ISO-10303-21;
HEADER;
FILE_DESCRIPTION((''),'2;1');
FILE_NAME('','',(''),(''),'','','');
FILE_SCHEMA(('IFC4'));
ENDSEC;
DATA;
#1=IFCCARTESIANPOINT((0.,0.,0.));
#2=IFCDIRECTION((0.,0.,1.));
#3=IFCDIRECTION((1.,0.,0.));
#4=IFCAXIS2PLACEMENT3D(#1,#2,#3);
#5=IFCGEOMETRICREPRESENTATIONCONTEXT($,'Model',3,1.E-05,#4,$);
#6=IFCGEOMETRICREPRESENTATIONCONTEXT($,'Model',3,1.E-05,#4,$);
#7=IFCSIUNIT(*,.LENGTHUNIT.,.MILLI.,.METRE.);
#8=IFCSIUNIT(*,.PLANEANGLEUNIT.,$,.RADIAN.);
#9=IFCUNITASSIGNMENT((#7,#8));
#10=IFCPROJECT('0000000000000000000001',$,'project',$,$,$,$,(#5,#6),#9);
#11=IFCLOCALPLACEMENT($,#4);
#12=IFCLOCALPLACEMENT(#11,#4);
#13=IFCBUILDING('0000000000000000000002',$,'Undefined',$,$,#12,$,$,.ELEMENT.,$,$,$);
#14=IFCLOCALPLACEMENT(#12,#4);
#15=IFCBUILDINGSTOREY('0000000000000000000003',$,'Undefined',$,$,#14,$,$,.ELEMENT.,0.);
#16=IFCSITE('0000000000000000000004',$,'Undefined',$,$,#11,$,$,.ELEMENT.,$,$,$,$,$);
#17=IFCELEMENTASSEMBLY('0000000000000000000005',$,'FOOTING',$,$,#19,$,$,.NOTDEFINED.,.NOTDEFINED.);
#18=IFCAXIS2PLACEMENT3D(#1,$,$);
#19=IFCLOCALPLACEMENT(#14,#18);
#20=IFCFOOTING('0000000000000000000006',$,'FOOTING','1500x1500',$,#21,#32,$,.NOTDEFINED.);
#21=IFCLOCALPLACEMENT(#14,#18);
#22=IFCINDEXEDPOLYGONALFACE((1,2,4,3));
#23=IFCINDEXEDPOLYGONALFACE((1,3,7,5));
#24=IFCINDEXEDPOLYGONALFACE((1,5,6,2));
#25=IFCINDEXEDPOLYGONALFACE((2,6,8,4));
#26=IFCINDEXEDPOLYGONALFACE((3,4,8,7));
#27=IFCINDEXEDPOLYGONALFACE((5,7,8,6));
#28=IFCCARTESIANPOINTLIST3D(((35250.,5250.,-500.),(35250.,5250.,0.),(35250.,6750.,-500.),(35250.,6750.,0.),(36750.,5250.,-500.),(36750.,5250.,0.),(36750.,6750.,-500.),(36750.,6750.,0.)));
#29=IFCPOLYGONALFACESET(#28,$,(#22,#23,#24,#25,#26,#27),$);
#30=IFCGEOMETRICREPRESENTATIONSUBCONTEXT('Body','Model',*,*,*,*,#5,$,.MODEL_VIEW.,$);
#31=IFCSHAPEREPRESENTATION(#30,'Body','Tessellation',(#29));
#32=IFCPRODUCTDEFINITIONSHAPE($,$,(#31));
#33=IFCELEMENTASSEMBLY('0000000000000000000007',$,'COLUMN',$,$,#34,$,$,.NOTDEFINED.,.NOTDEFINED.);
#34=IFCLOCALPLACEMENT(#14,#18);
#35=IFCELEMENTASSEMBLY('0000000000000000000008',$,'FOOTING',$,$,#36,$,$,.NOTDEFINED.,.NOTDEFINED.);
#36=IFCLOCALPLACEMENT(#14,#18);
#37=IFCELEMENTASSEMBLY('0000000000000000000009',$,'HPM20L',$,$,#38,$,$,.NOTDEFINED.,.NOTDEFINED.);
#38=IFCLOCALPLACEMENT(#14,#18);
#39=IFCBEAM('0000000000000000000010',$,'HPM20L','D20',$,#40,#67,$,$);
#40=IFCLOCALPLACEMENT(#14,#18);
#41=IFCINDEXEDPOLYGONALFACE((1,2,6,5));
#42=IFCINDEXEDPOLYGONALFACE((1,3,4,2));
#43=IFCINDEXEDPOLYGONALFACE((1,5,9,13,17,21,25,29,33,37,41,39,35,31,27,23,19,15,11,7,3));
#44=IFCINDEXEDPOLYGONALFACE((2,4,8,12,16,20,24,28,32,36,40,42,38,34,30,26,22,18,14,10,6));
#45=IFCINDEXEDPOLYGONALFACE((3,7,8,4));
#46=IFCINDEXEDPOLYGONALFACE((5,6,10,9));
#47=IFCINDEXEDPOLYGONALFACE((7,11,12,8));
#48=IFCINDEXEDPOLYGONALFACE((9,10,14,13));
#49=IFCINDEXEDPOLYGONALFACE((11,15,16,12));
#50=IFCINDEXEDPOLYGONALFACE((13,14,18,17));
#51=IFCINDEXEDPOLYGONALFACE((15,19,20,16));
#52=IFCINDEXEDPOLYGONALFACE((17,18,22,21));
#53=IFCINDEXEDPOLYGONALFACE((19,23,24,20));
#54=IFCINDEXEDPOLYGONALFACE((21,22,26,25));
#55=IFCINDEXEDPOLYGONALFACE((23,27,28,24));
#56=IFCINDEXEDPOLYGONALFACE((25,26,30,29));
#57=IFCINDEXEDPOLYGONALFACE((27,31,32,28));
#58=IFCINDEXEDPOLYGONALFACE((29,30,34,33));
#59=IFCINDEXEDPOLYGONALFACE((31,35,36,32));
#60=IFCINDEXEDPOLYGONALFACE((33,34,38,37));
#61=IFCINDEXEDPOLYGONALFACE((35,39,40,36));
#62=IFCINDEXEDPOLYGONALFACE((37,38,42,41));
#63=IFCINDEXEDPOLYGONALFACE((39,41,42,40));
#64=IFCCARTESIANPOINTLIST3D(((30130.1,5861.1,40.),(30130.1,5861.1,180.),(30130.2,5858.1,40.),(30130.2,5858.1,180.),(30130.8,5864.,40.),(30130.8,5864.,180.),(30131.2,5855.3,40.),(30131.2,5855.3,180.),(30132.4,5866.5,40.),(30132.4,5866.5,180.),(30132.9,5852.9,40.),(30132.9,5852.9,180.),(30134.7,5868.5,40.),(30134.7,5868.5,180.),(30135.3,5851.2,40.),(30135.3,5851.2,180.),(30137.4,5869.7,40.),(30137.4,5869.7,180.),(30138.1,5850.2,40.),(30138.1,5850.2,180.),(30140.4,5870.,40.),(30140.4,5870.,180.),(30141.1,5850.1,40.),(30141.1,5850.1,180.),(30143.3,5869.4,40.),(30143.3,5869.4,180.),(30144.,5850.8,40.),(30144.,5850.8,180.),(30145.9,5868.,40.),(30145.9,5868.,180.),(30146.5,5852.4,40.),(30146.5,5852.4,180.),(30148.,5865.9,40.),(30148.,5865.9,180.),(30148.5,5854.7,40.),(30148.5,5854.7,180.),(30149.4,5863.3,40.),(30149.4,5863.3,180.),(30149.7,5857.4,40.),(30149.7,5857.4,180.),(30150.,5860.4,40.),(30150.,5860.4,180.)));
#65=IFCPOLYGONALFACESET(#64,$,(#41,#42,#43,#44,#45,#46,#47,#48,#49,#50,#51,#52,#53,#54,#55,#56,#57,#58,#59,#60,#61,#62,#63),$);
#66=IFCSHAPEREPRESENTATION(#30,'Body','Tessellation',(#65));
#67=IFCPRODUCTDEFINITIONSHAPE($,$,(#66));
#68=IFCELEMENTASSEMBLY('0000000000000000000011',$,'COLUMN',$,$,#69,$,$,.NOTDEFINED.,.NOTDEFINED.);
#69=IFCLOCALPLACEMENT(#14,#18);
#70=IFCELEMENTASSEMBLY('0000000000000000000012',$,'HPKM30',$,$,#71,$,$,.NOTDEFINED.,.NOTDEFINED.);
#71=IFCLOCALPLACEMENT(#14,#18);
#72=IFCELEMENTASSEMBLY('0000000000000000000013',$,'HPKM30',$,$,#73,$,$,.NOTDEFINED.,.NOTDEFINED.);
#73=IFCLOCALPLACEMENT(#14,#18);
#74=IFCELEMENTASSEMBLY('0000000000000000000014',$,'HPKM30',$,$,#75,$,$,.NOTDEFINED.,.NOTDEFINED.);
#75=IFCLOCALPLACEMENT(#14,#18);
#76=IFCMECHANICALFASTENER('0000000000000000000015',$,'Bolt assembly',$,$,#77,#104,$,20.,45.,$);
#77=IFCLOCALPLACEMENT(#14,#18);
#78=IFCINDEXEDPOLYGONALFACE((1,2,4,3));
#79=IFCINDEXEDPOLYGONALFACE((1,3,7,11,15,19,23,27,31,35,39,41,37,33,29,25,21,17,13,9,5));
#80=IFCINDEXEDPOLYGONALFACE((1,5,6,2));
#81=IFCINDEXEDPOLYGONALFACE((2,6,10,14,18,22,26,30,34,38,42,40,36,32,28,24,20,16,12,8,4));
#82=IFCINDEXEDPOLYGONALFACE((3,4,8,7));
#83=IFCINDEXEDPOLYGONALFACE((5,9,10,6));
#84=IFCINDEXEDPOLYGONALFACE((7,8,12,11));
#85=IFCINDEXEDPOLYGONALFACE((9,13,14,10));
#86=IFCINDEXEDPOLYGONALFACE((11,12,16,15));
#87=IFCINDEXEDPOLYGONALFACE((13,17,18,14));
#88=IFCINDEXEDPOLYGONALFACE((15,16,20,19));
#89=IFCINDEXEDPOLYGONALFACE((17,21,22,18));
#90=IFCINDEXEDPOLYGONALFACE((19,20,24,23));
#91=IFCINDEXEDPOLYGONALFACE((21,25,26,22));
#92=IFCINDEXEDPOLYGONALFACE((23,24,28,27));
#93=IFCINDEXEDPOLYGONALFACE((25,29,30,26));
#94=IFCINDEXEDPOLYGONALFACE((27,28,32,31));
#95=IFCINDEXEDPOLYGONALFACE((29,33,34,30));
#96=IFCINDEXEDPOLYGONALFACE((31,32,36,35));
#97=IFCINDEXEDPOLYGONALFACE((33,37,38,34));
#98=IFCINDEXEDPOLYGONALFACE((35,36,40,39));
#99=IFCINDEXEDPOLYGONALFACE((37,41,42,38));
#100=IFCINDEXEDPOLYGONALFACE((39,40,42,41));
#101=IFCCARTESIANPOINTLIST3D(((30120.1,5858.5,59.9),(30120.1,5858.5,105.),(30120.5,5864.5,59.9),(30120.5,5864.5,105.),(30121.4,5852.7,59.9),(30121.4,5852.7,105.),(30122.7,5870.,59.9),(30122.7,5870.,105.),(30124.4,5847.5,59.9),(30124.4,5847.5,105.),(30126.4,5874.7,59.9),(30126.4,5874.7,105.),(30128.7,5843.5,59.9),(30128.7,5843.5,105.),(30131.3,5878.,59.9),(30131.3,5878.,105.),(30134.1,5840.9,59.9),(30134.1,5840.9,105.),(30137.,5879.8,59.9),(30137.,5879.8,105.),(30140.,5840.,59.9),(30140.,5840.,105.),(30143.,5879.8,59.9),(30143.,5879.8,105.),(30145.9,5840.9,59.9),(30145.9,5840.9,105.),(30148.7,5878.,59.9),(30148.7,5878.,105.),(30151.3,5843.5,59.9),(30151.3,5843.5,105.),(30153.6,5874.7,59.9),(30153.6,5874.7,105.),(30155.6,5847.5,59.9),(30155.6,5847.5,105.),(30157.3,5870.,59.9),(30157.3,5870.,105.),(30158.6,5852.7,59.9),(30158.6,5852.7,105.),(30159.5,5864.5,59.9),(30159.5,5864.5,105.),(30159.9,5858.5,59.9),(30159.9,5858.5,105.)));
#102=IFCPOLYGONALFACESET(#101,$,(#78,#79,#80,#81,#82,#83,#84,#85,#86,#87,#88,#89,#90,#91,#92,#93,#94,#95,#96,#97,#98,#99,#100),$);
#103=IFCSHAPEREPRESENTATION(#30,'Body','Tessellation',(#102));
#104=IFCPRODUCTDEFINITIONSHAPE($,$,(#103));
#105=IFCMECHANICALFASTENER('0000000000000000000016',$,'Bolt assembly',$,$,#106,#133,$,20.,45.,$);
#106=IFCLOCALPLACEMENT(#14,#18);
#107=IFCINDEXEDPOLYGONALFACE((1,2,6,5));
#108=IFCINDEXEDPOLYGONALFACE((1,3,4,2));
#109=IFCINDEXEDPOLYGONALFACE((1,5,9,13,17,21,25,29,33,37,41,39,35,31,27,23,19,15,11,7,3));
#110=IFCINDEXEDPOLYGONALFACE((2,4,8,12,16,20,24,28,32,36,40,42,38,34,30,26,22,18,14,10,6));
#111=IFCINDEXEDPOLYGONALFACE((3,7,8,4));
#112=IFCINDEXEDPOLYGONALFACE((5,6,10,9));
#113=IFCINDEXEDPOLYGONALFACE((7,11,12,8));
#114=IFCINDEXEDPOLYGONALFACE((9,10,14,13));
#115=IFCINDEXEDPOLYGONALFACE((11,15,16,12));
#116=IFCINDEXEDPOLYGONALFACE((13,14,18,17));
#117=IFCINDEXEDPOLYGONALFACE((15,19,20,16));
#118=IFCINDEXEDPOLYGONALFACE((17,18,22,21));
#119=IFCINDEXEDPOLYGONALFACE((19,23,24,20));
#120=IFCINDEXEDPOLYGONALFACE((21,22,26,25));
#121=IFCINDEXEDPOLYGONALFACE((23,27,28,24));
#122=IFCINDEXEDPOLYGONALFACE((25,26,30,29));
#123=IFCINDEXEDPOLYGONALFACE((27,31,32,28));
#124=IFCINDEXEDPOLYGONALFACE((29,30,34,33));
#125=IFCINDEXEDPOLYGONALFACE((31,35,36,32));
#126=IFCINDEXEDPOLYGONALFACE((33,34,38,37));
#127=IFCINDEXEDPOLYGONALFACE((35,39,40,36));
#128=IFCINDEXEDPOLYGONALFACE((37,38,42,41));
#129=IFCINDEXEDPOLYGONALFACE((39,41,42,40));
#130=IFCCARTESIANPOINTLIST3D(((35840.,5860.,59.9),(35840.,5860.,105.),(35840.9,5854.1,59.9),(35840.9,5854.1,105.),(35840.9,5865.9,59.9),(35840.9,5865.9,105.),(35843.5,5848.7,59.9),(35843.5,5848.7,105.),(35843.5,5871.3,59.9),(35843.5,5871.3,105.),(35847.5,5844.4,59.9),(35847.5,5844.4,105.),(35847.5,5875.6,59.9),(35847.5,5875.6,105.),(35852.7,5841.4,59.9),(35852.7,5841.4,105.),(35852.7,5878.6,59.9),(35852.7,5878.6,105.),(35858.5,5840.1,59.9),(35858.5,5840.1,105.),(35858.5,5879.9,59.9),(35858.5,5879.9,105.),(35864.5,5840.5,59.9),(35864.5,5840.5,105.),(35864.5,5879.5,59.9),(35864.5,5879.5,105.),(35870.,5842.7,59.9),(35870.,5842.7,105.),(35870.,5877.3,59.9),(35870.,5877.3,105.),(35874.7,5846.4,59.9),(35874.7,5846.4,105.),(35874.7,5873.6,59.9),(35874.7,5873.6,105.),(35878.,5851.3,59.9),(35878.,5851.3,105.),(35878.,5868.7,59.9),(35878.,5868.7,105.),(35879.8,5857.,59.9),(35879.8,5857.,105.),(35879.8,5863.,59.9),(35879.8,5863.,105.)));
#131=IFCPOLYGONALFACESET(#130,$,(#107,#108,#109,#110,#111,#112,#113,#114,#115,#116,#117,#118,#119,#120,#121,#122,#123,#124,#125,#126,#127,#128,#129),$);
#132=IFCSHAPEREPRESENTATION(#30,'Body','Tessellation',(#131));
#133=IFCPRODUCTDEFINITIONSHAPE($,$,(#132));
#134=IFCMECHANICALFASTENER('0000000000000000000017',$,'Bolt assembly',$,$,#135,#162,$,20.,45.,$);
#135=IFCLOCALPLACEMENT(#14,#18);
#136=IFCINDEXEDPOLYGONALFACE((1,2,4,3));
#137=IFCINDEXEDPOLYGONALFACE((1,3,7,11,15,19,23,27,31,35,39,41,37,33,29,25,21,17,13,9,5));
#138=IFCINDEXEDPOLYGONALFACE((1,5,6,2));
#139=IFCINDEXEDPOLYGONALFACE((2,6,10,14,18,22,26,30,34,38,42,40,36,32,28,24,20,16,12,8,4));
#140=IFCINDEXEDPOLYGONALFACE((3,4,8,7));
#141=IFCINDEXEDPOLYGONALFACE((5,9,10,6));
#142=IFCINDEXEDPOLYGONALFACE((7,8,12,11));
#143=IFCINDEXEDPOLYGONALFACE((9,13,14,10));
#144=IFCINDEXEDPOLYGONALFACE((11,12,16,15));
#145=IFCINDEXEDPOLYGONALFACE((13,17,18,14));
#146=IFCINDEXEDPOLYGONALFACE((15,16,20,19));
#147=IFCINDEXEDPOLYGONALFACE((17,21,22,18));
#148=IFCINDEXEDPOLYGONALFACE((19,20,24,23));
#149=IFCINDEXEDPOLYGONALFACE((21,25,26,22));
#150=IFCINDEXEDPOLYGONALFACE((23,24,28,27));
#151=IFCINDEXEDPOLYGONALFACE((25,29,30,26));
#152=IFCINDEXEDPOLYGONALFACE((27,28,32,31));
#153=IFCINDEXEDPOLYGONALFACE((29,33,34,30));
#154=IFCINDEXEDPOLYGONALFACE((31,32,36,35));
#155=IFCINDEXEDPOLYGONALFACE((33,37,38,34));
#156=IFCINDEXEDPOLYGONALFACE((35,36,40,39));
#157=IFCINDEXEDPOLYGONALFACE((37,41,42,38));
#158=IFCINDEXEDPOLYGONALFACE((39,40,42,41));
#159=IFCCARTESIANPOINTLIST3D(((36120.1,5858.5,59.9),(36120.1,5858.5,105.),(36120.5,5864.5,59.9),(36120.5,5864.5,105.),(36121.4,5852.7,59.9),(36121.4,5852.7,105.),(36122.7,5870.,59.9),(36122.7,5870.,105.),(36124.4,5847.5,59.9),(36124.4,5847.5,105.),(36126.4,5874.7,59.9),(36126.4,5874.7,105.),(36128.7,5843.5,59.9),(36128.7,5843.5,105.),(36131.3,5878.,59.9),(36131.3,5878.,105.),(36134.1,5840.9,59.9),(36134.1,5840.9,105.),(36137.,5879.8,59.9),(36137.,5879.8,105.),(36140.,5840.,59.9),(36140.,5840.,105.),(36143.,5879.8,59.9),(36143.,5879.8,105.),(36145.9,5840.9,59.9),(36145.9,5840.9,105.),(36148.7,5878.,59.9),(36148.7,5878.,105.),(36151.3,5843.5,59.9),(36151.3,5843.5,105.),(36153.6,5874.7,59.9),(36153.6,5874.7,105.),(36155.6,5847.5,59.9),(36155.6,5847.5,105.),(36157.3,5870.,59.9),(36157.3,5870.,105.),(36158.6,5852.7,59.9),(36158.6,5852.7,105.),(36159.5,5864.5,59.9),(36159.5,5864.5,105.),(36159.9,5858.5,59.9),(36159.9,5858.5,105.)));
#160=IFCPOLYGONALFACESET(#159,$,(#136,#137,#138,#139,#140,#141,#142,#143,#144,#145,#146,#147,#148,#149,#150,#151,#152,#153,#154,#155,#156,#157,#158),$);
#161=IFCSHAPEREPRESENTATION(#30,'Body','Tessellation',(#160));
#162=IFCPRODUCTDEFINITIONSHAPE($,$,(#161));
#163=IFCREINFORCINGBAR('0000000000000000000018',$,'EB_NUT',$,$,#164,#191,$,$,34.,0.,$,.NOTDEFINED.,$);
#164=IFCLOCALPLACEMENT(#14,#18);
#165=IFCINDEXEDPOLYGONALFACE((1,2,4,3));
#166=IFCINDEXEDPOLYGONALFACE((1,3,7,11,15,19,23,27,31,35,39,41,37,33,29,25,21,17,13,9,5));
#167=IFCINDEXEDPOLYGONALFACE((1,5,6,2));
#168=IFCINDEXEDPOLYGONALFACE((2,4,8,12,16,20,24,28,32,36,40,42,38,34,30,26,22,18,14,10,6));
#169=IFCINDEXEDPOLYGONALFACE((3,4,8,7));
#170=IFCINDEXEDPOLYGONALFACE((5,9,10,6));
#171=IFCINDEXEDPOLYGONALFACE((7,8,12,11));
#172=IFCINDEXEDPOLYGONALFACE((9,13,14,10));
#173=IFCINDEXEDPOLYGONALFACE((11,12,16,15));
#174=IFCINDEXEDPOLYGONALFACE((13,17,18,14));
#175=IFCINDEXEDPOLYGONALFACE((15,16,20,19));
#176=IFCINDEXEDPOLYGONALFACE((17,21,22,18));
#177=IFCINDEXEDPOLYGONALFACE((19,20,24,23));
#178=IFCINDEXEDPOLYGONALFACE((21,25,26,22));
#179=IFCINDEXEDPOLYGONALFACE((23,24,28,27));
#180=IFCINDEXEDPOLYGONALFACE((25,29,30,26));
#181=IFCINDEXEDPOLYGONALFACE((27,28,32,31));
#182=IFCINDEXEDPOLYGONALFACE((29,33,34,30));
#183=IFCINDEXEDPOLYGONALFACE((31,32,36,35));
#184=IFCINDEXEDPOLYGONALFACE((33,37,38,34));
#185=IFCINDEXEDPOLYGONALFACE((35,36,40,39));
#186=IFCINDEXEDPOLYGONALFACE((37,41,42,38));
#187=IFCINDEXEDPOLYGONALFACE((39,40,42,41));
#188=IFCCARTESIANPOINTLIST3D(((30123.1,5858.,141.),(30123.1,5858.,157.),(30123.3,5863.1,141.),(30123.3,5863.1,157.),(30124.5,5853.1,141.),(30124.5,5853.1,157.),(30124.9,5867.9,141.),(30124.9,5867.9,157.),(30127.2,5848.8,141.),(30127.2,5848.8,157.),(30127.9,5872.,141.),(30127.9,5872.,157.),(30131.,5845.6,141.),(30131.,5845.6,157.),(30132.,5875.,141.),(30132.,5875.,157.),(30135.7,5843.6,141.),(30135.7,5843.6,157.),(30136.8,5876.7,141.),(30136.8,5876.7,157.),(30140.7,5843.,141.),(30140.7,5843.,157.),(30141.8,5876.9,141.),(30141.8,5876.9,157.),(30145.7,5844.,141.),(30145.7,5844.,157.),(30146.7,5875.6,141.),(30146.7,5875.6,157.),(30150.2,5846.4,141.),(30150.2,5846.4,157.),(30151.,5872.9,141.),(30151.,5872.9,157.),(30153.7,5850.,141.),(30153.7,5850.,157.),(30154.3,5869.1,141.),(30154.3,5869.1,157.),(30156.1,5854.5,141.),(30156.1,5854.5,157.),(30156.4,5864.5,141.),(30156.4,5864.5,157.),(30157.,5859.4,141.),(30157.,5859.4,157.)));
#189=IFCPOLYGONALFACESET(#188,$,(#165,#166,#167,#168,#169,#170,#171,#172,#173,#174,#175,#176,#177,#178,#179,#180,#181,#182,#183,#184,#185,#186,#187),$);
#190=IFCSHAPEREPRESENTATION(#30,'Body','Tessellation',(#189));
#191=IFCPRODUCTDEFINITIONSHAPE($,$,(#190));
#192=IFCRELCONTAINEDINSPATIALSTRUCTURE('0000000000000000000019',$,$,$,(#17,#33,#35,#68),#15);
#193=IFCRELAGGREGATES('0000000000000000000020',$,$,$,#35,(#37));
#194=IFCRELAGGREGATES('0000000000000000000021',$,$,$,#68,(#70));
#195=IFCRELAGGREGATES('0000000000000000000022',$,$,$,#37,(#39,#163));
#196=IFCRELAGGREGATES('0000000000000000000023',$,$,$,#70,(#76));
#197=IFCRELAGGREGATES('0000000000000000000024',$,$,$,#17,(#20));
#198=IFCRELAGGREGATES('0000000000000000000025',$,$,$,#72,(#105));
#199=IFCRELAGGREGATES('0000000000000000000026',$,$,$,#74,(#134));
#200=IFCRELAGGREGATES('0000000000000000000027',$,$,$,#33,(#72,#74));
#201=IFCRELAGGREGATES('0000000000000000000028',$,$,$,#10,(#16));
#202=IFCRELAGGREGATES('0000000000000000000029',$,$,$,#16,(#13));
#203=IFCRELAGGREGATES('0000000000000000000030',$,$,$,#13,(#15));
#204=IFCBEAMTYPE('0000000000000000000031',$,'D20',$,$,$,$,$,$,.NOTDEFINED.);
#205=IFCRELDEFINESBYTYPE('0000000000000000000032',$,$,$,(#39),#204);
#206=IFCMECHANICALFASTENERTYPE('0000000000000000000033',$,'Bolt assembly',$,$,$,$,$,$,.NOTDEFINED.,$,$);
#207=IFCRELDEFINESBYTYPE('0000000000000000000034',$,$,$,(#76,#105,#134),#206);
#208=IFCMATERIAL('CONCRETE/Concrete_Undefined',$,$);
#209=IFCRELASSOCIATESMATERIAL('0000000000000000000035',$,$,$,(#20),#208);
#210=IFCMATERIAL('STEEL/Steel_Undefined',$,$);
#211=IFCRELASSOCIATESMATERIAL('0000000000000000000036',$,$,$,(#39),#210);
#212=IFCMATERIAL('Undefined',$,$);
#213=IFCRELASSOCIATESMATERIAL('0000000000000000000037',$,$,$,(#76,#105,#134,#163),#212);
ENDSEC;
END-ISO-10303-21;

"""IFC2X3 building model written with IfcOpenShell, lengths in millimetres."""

from ifc_helpers import new_model, entity, si_unit, frame, origin_with_axes, origin_2d_with_axis, place, context, subcontext, project, spatial, rectangle, circle, extrude, source, transform, mapped, material, type_object, element, aggregate, save


model = new_model("IFC2X3")

# Units and contexts
model_context_1 = context("Model", 3, precision=1e-05, world=origin_with_axes())
model_context_2 = context("Model", 3, precision=1e-05, world=origin_with_axes())
body_context = subcontext(model_context_1, "Body", "Model", "MODEL_VIEW")
ifc_project = project(units=[si_unit("LENGTHUNIT", "METRE", prefix="MILLI"), si_unit("PLANEANGLEUNIT", "RADIAN")], contexts=[model_context_1, model_context_2])

# Site, building, storey
site_placement = place(None, origin_with_axes())
site = spatial("IfcSite", under=ifc_project, at=site_placement, Name="Undefined", CompositionType="ELEMENT")
building_placement = place(site_placement, origin_with_axes())
building = spatial("IfcBuilding", under=site, at=building_placement, Name="Undefined", CompositionType="ELEMENT")
storey_placement = place(building_placement, origin_with_axes())
storey = spatial("IfcBuildingStorey", under=building, at=storey_placement, Name="Undefined", CompositionType="ELEMENT", Elevation=0.0)

# Element assembly, footing
assembly_1_placement = place(storey_placement, origin_with_axes())
assembly_1 = element("IfcElementAssembly", 1, at=assembly_1_placement, inside=storey, Name="FOOTING", AssemblyPlace="NOTDEFINED", PredefinedType="NOTDEFINED")
ifc_material_1 = material(Name="CONCRETE/Concrete_Undefined")
footing_placement = place(assembly_1_placement, frame((36000.0, 6000.0, -500.0), z_axis=(0.0, 1.0, 0.0), x_axis=(0.0, 0.0, 1.0)))
footing = element("IfcFooting", 2, at=footing_placement, material=ifc_material_1, Name="FOOTING", Description="1500x1500", PredefinedType="NOTDEFINED", context=body_context, shape_type="SweptSolid", body=[
    extrude(rectangle(XDim=1500.0, YDim=1500.0, at=origin_2d_with_axis()), frame((500.0, 0.0, 0.0), z_axis=(-1.0, 0.0, 0.0), x_axis=(0.0, -1.0, 0.0)), (0.0, 0.0, 1.0), 500.0),
])

# Element assembly
assembly_2_placement = place(storey_placement, origin_with_axes())
assembly_2 = element("IfcElementAssembly", 3, at=assembly_2_placement, inside=storey, Name="COLUMN", AssemblyPlace="NOTDEFINED", PredefinedType="NOTDEFINED")

# Element assemblies, beam
assembly_3_placement = place(storey_placement, origin_with_axes())
assembly_3 = element("IfcElementAssembly", 4, at=assembly_3_placement, inside=storey, Name="FOOTING", AssemblyPlace="NOTDEFINED", PredefinedType="NOTDEFINED")
assembly_4_placement = place(assembly_3_placement, origin_with_axes())
assembly_4 = element("IfcElementAssembly", 5, at=assembly_4_placement, Name="HPM20L", AssemblyPlace="NOTDEFINED", PredefinedType="NOTDEFINED")
aggregate(assembly_3, [assembly_4])
ifc_material_2 = material(Name="STEEL/Steel_Undefined")
beam_type = type_object("IfcBeamType", Name="D20", PredefinedType="NOTDEFINED")
beam_placement = place(assembly_4_placement, frame((30140.0, 5860.0, 180.0), z_axis=(0.707107, -0.707107, 0.0), x_axis=(0.0, 0.0, -1.0)))
beam = element("IfcBeam", 6, at=beam_placement, type_object=beam_type, material=ifc_material_2, Name="HPM20L", Description="D20", context=body_context, shape_type="SweptSolid", body=[
    extrude(circle(Radius=10.0, at=origin_2d_with_axis()), frame((140.0, 0.0, 0.0), z_axis=(-1.0, 0.0, 0.0), x_axis=(0.0, -1.0, 0.0)), (0.0, 0.0, 1.0), 140.0),
])

# Element assemblies
assembly_5_placement = place(storey_placement, origin_with_axes())
assembly_5 = element("IfcElementAssembly", 7, at=assembly_5_placement, inside=storey, Name="COLUMN", AssemblyPlace="NOTDEFINED", PredefinedType="NOTDEFINED")
assembly_6_placement = place(assembly_5_placement, origin_with_axes())
assembly_6 = element("IfcElementAssembly", 8, at=assembly_6_placement, Name="HPKM30", AssemblyPlace="NOTDEFINED", PredefinedType="NOTDEFINED")
aggregate(assembly_5, [assembly_6])

# Element assemblies
assembly_7_placement = place(assembly_2_placement, origin_with_axes())
assembly_7 = element("IfcElementAssembly", 9, at=assembly_7_placement, Name="HPKM30", AssemblyPlace="NOTDEFINED", PredefinedType="NOTDEFINED")
assembly_8_placement = place(assembly_2_placement, origin_with_axes())
assembly_8 = element("IfcElementAssembly", 10, at=assembly_8_placement, Name="HPKM30", AssemblyPlace="NOTDEFINED", PredefinedType="NOTDEFINED")

# Mechanical fasteners
ifc_material_3 = material(Name="Undefined")
mechanical_fastener_type = type_object("IfcMechanicalFastenerType", Name="Bolt assembly")
shared_shape_1 = source(origin_with_axes(), body_context, "Body", "SweptSolid", [
    extrude(circle(Radius=20.0, at=origin_2d_with_axis()), frame((0.0, -45.0, 0.0), z_axis=(0.0, 1.0, 0.0), x_axis=(1.0, 0.0, 0.0)), (0.0, 0.0, 1.0), 45.1),
])
mechanical_fastener_1_placement = place(assembly_6_placement, frame((30140.0, 5860.0, 60.0), z_axis=(1.0, 0.0, 0.0), x_axis=(0.0, -1.0, 0.0)))
mechanical_fastener_1 = element("IfcMechanicalFastener", 11, at=mechanical_fastener_1_placement, type_object=mechanical_fastener_type, material=ifc_material_3, Name="Bolt assembly", NominalDiameter=20.0, NominalLength=45.0, context=body_context, shape_type="MappedRepresentation", body=[
    mapped(shared_shape_1, transform((0.0, 0.0, 0.0))),
])
mechanical_fastener_2_placement = place(assembly_7_placement, frame((35860.0, 5860.0, 60.0), z_axis=(0.0, -1.0, 0.0), x_axis=(-1.0, 0.0, 0.0)))
mechanical_fastener_2 = element("IfcMechanicalFastener", 12, at=mechanical_fastener_2_placement, type_object=mechanical_fastener_type, material=ifc_material_3, Name="Bolt assembly", NominalDiameter=20.0, NominalLength=45.0, context=body_context, shape_type="MappedRepresentation", body=[
    mapped(shared_shape_1, transform((0.0, 0.0, 0.0))),
])
mechanical_fastener_3_placement = place(assembly_8_placement, frame((36140.0, 5860.0, 60.0), z_axis=(1.0, 0.0, 0.0), x_axis=(0.0, -1.0, 0.0)))
mechanical_fastener_3 = element("IfcMechanicalFastener", 13, at=mechanical_fastener_3_placement, type_object=mechanical_fastener_type, material=ifc_material_3, Name="Bolt assembly", NominalDiameter=20.0, NominalLength=45.0, context=body_context, shape_type="MappedRepresentation", body=[
    mapped(shared_shape_1, transform((0.0, 0.0, 0.0))),
])

# Reinforcing bar
shared_shape_2 = source(origin_with_axes(), body_context, "Body", "AdvancedSweptSolid", [
    entity("IfcSweptDiskSolid", entity("IfcTrimmedCurve", entity("IfcLine", entity("IfcCartesianPoint", [0.0, 0.0, 0.0]), entity("IfcVector", entity("IfcDirection", [1.0, 0.0, 0.0]), 1.0)), [entity("IfcParameterValue", 0.0)], [entity("IfcParameterValue", 16.0)], True, "PARAMETER"), 17.0, None, 0.0, 16.0),
])
reinforcing_bar_1_placement = place(assembly_4_placement, frame((30140.0, 5860.0, 157.0), z_axis=(-0.190852, 0.981619, 0.0), x_axis=(0.0, 0.0, -1.0)))
reinforcing_bar_1 = element("IfcReinforcingBar", 14, at=reinforcing_bar_1_placement, material=ifc_material_3, Name="EB_NUT", BarRole="NOTDEFINED", CrossSectionArea=0.0, NominalDiameter=34.0, context=body_context, shape_type="MappedRepresentation", body=[
    mapped(shared_shape_2, transform((0.0, 0.0, 0.0))),
])
aggregate(assembly_4, [beam, reinforcing_bar_1])
aggregate(assembly_6, [mechanical_fastener_1])

aggregate(assembly_1, [footing])

aggregate(assembly_7, [mechanical_fastener_2])
aggregate(assembly_8, [mechanical_fastener_3])
aggregate(assembly_2, [assembly_7, assembly_8])

save(model, "model.ifc")
